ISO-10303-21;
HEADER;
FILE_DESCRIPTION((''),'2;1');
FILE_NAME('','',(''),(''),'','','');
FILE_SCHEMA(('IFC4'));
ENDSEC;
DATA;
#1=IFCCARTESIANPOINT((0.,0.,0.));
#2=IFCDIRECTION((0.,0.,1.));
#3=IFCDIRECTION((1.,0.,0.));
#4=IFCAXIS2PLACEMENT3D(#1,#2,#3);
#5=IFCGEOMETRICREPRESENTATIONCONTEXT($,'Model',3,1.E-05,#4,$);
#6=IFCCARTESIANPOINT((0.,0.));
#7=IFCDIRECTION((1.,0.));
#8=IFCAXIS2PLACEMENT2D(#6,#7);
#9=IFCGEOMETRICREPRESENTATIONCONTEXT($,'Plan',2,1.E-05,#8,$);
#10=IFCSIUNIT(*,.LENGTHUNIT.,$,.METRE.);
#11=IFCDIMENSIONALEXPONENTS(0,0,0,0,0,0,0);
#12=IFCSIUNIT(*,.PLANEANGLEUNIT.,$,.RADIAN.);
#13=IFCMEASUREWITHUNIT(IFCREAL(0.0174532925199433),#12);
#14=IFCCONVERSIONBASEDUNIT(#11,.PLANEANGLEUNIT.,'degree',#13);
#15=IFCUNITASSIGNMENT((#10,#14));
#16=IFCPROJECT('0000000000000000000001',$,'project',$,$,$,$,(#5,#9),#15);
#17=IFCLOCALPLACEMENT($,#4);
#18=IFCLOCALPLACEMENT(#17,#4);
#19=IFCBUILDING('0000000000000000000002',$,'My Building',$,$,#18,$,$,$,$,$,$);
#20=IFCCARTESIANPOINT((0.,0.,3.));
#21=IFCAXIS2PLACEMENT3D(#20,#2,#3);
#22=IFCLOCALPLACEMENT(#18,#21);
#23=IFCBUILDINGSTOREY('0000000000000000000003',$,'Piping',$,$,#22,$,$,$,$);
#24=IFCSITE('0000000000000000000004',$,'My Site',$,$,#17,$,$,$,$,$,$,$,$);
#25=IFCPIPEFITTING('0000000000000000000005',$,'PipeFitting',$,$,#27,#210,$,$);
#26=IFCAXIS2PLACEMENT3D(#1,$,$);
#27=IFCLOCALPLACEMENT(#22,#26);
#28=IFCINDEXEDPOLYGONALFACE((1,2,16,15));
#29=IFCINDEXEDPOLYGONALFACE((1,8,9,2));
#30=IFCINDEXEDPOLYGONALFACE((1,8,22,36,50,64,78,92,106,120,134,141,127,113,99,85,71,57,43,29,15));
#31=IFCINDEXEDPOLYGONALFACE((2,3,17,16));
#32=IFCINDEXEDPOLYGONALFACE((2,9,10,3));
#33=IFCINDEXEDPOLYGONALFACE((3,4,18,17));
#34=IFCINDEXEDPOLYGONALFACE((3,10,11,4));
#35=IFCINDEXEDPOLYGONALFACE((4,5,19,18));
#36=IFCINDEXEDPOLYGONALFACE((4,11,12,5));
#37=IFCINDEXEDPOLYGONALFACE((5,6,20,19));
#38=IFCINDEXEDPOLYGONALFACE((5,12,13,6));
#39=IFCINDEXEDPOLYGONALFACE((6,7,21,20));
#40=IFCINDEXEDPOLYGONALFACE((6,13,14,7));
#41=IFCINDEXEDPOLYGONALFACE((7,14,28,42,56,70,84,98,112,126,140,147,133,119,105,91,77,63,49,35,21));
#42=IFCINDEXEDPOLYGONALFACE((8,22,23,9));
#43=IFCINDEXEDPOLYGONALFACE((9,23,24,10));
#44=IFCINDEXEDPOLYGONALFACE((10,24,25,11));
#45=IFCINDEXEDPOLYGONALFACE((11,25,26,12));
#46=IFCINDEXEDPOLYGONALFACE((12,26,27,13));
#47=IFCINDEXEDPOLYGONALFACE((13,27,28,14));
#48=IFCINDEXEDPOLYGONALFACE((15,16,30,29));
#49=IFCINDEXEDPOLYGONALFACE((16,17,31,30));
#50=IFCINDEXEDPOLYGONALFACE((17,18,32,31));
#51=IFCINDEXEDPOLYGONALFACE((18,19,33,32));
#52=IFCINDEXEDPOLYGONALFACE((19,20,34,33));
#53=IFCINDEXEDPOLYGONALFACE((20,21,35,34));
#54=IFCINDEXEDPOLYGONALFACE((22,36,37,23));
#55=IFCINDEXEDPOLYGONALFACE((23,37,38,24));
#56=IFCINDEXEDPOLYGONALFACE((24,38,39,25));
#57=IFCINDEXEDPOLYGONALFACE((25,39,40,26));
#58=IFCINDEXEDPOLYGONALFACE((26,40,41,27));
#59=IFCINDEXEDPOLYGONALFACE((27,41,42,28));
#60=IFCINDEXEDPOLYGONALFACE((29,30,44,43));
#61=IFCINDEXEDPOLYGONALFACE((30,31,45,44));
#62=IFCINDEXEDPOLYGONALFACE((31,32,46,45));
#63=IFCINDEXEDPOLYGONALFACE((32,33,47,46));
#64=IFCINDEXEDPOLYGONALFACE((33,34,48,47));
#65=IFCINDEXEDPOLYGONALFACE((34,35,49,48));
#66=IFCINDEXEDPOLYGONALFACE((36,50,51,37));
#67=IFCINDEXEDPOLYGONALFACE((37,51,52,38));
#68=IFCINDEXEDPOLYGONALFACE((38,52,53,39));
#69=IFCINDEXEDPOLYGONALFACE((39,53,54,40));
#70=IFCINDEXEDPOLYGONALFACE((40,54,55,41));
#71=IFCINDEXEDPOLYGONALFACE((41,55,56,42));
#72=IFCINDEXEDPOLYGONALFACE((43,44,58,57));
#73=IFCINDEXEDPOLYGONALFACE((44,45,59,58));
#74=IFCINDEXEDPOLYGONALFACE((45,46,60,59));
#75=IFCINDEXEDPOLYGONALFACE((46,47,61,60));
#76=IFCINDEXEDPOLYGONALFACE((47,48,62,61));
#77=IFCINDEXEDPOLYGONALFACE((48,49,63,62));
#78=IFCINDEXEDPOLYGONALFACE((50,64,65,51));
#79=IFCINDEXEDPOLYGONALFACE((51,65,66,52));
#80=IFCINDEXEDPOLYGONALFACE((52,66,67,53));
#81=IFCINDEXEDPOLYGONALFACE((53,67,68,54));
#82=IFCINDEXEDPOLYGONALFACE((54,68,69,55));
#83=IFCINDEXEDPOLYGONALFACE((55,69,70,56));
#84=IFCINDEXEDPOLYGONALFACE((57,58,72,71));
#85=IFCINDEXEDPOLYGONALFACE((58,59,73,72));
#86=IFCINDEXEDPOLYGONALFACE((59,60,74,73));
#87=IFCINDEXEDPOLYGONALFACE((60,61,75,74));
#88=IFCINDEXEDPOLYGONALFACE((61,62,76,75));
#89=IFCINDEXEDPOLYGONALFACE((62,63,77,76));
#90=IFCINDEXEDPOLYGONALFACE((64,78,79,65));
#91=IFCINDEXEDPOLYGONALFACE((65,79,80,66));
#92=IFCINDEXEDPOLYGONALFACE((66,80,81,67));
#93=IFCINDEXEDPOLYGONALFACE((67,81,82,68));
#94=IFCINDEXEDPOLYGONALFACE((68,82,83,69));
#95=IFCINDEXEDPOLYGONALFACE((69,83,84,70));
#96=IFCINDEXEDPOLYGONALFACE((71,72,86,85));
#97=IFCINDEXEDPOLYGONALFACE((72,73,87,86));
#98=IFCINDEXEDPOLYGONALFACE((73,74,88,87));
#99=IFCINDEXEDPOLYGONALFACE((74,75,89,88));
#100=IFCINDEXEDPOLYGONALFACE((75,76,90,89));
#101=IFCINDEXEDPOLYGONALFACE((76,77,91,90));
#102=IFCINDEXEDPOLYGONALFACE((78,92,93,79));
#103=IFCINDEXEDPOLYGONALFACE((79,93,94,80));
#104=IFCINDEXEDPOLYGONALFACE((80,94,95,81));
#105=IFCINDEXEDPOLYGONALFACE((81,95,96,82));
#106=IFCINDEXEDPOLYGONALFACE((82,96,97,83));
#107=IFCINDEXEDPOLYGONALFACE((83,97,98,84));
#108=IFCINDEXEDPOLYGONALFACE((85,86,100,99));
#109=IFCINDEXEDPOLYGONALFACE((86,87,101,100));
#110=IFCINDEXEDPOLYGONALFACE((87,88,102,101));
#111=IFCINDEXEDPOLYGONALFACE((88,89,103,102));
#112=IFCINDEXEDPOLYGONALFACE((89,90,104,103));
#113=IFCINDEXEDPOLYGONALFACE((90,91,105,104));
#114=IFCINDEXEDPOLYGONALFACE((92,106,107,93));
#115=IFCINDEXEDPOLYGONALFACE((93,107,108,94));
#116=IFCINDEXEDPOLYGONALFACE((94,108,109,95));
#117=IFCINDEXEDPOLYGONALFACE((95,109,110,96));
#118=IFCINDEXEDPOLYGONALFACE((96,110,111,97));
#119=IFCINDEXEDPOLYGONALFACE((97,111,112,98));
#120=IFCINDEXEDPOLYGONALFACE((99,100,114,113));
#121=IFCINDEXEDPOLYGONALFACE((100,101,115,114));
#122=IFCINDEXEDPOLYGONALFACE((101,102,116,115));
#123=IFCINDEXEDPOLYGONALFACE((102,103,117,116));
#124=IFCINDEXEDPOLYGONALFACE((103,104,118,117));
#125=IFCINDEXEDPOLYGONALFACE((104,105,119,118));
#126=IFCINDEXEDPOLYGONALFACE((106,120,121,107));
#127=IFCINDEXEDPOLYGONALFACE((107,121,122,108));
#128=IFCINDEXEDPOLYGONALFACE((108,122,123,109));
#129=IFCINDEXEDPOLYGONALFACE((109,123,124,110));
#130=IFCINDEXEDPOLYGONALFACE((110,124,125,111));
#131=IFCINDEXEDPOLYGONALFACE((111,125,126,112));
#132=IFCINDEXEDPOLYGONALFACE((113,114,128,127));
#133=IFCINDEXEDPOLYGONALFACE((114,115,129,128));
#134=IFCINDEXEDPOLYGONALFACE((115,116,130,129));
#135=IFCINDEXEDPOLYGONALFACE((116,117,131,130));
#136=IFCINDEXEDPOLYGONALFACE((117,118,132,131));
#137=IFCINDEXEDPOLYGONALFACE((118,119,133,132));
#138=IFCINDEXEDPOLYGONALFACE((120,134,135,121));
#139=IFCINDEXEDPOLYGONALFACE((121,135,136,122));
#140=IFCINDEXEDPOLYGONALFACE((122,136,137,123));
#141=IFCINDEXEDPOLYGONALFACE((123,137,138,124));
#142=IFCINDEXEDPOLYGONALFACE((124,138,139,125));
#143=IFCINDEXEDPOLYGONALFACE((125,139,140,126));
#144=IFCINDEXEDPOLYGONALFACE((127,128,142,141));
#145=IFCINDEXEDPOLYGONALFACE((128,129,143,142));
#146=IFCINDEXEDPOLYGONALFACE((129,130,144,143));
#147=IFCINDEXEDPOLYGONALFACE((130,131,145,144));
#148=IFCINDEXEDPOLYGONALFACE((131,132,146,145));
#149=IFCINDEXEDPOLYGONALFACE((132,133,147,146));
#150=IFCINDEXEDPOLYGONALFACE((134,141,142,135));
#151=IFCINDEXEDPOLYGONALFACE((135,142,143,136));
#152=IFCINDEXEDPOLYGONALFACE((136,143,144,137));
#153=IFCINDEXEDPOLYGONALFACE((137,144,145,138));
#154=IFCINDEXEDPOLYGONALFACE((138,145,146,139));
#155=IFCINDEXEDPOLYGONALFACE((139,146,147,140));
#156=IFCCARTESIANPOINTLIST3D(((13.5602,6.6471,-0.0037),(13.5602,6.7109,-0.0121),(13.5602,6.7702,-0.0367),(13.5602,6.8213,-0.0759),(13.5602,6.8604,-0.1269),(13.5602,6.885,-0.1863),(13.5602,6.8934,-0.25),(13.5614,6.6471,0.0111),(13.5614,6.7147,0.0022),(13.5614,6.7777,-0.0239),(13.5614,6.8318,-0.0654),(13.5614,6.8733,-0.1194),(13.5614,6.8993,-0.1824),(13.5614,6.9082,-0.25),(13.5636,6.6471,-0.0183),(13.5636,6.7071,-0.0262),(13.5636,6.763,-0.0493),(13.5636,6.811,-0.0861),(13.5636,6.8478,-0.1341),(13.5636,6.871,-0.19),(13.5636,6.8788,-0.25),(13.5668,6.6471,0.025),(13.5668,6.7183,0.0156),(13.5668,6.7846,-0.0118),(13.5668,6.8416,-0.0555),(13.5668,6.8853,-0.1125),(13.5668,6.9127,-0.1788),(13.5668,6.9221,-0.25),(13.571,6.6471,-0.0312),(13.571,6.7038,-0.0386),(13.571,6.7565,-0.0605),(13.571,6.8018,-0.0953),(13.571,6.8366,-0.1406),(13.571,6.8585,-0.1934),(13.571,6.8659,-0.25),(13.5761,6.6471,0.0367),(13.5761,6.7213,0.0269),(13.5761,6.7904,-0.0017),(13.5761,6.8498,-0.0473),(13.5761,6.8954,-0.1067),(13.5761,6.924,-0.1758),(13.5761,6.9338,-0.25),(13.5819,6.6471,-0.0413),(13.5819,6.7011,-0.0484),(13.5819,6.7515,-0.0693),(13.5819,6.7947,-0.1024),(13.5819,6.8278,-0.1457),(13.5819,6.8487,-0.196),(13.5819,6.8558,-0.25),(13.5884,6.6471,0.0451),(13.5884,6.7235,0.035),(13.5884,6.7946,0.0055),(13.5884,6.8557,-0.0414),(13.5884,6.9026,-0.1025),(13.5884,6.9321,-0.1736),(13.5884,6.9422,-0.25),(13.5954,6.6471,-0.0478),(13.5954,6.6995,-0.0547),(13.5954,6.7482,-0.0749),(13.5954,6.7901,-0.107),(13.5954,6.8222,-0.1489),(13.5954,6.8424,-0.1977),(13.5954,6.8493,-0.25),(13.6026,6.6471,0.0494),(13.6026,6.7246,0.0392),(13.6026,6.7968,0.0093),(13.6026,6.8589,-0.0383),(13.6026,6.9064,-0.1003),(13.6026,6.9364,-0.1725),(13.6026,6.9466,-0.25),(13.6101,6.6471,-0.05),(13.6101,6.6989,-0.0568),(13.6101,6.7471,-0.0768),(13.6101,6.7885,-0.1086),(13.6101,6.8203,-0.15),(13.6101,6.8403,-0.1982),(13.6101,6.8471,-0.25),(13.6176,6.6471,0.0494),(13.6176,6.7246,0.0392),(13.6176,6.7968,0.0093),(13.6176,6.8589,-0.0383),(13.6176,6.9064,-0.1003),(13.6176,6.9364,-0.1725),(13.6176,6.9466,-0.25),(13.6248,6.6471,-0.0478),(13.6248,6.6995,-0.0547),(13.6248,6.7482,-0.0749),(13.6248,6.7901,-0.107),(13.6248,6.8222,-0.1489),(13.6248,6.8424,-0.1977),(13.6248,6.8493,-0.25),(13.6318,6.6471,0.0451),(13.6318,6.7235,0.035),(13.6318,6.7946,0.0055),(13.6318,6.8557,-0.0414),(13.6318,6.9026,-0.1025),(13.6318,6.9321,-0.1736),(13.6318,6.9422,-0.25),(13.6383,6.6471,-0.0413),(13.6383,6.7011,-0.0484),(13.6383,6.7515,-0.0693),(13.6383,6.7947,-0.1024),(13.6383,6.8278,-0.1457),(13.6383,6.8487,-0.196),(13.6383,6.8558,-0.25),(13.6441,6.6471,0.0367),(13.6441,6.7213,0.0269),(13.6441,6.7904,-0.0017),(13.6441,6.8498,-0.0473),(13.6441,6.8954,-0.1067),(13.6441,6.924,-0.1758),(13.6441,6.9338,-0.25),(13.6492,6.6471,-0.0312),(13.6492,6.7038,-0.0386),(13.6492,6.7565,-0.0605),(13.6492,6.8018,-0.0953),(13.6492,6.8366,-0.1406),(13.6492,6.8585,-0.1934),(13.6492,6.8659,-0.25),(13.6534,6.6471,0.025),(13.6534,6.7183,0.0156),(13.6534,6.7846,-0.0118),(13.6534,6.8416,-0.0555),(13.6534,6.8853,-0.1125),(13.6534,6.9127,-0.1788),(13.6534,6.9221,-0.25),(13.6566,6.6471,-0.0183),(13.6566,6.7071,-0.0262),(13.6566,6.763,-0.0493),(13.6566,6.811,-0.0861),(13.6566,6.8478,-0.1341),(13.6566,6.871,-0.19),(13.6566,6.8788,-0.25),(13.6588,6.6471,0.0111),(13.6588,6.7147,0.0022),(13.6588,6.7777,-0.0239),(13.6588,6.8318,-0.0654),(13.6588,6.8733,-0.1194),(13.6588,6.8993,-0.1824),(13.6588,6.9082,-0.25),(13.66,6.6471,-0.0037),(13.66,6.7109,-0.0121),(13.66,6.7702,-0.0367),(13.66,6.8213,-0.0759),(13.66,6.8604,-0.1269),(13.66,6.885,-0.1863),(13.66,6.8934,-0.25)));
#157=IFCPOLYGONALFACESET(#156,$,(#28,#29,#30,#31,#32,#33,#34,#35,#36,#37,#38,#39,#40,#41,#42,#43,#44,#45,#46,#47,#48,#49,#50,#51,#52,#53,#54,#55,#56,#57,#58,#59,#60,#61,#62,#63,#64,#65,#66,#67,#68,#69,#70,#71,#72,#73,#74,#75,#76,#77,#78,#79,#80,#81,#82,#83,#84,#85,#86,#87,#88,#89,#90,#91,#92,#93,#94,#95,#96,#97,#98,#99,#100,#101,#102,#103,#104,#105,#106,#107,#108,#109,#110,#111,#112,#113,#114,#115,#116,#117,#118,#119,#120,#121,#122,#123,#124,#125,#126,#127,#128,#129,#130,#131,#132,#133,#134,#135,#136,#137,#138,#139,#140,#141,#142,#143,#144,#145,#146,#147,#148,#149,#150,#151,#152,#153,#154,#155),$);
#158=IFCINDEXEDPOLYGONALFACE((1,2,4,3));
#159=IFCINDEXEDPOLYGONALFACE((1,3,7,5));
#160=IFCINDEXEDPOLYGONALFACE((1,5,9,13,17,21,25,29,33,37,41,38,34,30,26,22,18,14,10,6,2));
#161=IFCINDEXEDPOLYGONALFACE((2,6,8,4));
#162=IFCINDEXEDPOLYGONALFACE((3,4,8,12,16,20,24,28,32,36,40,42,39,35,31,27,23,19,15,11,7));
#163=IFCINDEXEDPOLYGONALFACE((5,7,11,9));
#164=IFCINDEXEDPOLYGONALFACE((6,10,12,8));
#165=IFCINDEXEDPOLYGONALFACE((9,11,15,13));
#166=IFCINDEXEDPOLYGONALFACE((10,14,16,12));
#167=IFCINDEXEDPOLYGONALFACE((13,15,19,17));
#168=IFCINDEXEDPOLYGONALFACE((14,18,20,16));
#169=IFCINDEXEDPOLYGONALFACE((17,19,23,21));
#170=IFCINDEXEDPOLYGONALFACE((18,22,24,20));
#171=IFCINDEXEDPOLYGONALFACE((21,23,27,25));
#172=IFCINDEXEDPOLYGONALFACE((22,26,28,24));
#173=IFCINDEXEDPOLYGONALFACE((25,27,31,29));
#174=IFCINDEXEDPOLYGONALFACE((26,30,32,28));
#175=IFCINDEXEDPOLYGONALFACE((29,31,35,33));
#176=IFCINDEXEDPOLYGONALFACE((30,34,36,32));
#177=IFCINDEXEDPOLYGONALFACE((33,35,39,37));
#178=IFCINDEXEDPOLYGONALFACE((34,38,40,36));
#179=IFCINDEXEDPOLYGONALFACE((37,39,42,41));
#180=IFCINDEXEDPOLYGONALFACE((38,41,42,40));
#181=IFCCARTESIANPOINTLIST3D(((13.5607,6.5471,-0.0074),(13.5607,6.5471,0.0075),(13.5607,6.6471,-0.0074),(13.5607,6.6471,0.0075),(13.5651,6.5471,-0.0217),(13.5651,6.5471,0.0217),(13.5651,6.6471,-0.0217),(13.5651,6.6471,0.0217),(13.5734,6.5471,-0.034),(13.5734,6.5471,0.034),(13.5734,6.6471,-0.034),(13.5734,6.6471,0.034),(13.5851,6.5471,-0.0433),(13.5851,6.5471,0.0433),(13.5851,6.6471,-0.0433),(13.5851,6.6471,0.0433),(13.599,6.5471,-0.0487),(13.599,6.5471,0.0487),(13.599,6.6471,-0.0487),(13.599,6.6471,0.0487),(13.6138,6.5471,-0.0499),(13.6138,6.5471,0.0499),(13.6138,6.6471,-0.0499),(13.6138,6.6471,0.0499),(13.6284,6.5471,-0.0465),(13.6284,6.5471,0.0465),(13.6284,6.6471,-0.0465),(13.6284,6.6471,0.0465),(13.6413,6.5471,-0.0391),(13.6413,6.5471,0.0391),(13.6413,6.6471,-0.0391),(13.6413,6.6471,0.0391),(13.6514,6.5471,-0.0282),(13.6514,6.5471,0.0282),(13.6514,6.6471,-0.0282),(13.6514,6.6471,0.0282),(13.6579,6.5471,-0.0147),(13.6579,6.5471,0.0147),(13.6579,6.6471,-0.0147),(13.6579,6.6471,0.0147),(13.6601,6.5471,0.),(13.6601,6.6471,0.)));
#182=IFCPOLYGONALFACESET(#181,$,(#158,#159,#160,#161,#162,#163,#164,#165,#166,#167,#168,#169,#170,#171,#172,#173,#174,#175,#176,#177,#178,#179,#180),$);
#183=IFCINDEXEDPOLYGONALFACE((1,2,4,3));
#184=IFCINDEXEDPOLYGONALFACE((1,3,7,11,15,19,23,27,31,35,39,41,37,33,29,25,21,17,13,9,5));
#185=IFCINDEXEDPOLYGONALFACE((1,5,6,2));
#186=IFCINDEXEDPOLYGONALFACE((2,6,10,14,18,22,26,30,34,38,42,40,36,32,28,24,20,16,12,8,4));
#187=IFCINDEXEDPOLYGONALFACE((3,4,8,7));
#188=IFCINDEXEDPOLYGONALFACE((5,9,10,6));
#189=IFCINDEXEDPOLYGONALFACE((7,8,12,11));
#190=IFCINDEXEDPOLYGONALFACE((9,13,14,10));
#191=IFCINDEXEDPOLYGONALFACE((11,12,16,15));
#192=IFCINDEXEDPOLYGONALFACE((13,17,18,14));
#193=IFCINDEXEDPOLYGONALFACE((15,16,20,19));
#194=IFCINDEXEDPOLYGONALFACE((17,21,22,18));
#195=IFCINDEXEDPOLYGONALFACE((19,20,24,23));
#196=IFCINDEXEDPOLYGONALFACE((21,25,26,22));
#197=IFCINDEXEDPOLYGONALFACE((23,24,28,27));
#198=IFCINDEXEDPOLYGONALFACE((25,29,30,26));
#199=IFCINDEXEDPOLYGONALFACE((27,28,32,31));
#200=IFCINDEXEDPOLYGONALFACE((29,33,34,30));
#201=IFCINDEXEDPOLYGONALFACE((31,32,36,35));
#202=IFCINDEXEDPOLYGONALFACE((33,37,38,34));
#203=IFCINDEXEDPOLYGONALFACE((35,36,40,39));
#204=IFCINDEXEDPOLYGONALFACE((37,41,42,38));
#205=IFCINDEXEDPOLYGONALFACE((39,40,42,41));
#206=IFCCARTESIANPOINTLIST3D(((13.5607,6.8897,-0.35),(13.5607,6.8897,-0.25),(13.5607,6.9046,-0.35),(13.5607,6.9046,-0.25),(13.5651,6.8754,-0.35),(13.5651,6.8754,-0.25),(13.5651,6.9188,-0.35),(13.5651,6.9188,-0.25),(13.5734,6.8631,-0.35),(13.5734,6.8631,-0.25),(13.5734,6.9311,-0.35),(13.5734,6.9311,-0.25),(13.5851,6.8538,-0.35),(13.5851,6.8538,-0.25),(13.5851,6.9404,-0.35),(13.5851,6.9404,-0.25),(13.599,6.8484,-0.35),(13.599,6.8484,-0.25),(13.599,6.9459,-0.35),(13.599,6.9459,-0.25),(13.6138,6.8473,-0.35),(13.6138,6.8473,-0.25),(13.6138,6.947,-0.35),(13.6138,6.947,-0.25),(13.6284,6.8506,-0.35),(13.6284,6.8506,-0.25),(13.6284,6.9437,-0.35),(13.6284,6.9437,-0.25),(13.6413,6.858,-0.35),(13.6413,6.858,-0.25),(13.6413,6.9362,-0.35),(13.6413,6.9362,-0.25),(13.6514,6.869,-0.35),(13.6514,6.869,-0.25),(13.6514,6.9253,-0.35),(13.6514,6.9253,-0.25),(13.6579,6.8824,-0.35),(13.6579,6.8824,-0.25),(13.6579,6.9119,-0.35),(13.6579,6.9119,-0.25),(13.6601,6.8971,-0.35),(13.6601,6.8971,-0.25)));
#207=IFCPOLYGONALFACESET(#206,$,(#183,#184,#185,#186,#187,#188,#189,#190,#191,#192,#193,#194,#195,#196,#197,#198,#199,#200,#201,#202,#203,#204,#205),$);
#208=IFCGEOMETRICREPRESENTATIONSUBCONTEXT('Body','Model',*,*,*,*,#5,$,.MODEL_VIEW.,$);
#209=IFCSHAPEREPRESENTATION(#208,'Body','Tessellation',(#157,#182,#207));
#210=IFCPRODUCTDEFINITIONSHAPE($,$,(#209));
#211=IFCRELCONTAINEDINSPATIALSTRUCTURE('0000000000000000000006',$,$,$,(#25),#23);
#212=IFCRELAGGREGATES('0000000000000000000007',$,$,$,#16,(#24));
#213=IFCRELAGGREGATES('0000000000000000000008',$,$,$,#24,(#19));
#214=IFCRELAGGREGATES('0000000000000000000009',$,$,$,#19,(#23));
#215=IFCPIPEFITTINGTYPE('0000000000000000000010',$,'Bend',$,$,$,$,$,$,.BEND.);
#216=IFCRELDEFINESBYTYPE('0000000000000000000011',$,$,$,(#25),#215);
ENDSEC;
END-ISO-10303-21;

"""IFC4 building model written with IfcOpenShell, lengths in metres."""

from ifc_helpers import new_model, entity, si_unit, converted_unit, frame, origin_with_axes, origin_2d_with_axis, place, context, subcontext, project, spatial, circle, extrude, source, transform, mapped, type_object, type_shapes, element, save


model = new_model("IFC4")

# Units and contexts
model_context = context("Model", 3, precision=1e-05, world=origin_with_axes())
plan_context = context("Plan", 2, precision=1e-05, world=origin_2d_with_axis())
body_context = subcontext(model_context, "Body", "Model", "MODEL_VIEW")
ifc_project = project(units=[si_unit("LENGTHUNIT", "METRE"), converted_unit("PLANEANGLEUNIT", "degree", entity("IfcReal", 0.0174532925199433), si_unit("PLANEANGLEUNIT", "RADIAN"), dimensions=[0, 0, 0, 0, 0, 0, 0])], contexts=[model_context, plan_context])

# Site, building, storey
site_placement = place(None, origin_with_axes())
site = spatial("IfcSite", under=ifc_project, at=site_placement, Name="My Site")
building_placement = place(site_placement, origin_with_axes())
building = spatial("IfcBuilding", under=site, at=building_placement, Name="My Building")
storey_placement = place(building_placement, frame((0.0, 0.0, 3.0), z_axis=(0.0, 0.0, 1.0), x_axis=(1.0, 0.0, 0.0)))
storey = spatial("IfcBuildingStorey", under=building, at=storey_placement, Name="Piping")

# Pipe fitting
pipe_fitting_type = type_object("IfcPipeFittingType", Name="Bend", PredefinedType="BEND")
shared_shape = source(origin_with_axes(), body_context, "Body", "SolidModel", [
    entity("IfcSweptDiskSolid", entity("IfcIndexedPolyCurve", entity("IfcCartesianPointList3D", [[0.0, 0.0, -0.1], [0.0, -0.0732, -0.2768], [0.0, -0.25, -0.35]]), [entity("IfcArcIndex", [1, 2, 3])]), 0.05),
    extrude(circle(Radius=0.05), origin_with_axes(), (0.0, 0.0, -1.0), 0.1),
    extrude(circle(Radius=0.05), frame((0.0, -0.25, -0.35), z_axis=(0.0, -1.0, 0.0), x_axis=(1.0, 0.0, 0.0)), (0.0, 0.0, 1.0), 0.1),
])
type_shapes(pipe_fitting_type, [shared_shape])
for number, where, z_axis, x_axis, name in (
    (1, (13.6101, 6.5471, 0.0), (0.0, -1.0, 0.0), (1.0, 0.0, 0.0), "PipeFitting"),
):
    element("IfcPipeFitting", number, at=place(storey_placement, frame(where, z_axis=z_axis, x_axis=x_axis)), inside=storey, type_object=pipe_fitting_type, Name=name, context=body_context, shape_type="MappedRepresentation", body=[
        mapped(shared_shape, transform((0.0, 0.0, 0.0), x_axis=(1.0, 0.0, 0.0), y_axis=(0.0, 1.0, 0.0), z_axis=(0.0, 0.0, 1.0), scale=1.0)),
    ])

save(model, "model.ifc")
